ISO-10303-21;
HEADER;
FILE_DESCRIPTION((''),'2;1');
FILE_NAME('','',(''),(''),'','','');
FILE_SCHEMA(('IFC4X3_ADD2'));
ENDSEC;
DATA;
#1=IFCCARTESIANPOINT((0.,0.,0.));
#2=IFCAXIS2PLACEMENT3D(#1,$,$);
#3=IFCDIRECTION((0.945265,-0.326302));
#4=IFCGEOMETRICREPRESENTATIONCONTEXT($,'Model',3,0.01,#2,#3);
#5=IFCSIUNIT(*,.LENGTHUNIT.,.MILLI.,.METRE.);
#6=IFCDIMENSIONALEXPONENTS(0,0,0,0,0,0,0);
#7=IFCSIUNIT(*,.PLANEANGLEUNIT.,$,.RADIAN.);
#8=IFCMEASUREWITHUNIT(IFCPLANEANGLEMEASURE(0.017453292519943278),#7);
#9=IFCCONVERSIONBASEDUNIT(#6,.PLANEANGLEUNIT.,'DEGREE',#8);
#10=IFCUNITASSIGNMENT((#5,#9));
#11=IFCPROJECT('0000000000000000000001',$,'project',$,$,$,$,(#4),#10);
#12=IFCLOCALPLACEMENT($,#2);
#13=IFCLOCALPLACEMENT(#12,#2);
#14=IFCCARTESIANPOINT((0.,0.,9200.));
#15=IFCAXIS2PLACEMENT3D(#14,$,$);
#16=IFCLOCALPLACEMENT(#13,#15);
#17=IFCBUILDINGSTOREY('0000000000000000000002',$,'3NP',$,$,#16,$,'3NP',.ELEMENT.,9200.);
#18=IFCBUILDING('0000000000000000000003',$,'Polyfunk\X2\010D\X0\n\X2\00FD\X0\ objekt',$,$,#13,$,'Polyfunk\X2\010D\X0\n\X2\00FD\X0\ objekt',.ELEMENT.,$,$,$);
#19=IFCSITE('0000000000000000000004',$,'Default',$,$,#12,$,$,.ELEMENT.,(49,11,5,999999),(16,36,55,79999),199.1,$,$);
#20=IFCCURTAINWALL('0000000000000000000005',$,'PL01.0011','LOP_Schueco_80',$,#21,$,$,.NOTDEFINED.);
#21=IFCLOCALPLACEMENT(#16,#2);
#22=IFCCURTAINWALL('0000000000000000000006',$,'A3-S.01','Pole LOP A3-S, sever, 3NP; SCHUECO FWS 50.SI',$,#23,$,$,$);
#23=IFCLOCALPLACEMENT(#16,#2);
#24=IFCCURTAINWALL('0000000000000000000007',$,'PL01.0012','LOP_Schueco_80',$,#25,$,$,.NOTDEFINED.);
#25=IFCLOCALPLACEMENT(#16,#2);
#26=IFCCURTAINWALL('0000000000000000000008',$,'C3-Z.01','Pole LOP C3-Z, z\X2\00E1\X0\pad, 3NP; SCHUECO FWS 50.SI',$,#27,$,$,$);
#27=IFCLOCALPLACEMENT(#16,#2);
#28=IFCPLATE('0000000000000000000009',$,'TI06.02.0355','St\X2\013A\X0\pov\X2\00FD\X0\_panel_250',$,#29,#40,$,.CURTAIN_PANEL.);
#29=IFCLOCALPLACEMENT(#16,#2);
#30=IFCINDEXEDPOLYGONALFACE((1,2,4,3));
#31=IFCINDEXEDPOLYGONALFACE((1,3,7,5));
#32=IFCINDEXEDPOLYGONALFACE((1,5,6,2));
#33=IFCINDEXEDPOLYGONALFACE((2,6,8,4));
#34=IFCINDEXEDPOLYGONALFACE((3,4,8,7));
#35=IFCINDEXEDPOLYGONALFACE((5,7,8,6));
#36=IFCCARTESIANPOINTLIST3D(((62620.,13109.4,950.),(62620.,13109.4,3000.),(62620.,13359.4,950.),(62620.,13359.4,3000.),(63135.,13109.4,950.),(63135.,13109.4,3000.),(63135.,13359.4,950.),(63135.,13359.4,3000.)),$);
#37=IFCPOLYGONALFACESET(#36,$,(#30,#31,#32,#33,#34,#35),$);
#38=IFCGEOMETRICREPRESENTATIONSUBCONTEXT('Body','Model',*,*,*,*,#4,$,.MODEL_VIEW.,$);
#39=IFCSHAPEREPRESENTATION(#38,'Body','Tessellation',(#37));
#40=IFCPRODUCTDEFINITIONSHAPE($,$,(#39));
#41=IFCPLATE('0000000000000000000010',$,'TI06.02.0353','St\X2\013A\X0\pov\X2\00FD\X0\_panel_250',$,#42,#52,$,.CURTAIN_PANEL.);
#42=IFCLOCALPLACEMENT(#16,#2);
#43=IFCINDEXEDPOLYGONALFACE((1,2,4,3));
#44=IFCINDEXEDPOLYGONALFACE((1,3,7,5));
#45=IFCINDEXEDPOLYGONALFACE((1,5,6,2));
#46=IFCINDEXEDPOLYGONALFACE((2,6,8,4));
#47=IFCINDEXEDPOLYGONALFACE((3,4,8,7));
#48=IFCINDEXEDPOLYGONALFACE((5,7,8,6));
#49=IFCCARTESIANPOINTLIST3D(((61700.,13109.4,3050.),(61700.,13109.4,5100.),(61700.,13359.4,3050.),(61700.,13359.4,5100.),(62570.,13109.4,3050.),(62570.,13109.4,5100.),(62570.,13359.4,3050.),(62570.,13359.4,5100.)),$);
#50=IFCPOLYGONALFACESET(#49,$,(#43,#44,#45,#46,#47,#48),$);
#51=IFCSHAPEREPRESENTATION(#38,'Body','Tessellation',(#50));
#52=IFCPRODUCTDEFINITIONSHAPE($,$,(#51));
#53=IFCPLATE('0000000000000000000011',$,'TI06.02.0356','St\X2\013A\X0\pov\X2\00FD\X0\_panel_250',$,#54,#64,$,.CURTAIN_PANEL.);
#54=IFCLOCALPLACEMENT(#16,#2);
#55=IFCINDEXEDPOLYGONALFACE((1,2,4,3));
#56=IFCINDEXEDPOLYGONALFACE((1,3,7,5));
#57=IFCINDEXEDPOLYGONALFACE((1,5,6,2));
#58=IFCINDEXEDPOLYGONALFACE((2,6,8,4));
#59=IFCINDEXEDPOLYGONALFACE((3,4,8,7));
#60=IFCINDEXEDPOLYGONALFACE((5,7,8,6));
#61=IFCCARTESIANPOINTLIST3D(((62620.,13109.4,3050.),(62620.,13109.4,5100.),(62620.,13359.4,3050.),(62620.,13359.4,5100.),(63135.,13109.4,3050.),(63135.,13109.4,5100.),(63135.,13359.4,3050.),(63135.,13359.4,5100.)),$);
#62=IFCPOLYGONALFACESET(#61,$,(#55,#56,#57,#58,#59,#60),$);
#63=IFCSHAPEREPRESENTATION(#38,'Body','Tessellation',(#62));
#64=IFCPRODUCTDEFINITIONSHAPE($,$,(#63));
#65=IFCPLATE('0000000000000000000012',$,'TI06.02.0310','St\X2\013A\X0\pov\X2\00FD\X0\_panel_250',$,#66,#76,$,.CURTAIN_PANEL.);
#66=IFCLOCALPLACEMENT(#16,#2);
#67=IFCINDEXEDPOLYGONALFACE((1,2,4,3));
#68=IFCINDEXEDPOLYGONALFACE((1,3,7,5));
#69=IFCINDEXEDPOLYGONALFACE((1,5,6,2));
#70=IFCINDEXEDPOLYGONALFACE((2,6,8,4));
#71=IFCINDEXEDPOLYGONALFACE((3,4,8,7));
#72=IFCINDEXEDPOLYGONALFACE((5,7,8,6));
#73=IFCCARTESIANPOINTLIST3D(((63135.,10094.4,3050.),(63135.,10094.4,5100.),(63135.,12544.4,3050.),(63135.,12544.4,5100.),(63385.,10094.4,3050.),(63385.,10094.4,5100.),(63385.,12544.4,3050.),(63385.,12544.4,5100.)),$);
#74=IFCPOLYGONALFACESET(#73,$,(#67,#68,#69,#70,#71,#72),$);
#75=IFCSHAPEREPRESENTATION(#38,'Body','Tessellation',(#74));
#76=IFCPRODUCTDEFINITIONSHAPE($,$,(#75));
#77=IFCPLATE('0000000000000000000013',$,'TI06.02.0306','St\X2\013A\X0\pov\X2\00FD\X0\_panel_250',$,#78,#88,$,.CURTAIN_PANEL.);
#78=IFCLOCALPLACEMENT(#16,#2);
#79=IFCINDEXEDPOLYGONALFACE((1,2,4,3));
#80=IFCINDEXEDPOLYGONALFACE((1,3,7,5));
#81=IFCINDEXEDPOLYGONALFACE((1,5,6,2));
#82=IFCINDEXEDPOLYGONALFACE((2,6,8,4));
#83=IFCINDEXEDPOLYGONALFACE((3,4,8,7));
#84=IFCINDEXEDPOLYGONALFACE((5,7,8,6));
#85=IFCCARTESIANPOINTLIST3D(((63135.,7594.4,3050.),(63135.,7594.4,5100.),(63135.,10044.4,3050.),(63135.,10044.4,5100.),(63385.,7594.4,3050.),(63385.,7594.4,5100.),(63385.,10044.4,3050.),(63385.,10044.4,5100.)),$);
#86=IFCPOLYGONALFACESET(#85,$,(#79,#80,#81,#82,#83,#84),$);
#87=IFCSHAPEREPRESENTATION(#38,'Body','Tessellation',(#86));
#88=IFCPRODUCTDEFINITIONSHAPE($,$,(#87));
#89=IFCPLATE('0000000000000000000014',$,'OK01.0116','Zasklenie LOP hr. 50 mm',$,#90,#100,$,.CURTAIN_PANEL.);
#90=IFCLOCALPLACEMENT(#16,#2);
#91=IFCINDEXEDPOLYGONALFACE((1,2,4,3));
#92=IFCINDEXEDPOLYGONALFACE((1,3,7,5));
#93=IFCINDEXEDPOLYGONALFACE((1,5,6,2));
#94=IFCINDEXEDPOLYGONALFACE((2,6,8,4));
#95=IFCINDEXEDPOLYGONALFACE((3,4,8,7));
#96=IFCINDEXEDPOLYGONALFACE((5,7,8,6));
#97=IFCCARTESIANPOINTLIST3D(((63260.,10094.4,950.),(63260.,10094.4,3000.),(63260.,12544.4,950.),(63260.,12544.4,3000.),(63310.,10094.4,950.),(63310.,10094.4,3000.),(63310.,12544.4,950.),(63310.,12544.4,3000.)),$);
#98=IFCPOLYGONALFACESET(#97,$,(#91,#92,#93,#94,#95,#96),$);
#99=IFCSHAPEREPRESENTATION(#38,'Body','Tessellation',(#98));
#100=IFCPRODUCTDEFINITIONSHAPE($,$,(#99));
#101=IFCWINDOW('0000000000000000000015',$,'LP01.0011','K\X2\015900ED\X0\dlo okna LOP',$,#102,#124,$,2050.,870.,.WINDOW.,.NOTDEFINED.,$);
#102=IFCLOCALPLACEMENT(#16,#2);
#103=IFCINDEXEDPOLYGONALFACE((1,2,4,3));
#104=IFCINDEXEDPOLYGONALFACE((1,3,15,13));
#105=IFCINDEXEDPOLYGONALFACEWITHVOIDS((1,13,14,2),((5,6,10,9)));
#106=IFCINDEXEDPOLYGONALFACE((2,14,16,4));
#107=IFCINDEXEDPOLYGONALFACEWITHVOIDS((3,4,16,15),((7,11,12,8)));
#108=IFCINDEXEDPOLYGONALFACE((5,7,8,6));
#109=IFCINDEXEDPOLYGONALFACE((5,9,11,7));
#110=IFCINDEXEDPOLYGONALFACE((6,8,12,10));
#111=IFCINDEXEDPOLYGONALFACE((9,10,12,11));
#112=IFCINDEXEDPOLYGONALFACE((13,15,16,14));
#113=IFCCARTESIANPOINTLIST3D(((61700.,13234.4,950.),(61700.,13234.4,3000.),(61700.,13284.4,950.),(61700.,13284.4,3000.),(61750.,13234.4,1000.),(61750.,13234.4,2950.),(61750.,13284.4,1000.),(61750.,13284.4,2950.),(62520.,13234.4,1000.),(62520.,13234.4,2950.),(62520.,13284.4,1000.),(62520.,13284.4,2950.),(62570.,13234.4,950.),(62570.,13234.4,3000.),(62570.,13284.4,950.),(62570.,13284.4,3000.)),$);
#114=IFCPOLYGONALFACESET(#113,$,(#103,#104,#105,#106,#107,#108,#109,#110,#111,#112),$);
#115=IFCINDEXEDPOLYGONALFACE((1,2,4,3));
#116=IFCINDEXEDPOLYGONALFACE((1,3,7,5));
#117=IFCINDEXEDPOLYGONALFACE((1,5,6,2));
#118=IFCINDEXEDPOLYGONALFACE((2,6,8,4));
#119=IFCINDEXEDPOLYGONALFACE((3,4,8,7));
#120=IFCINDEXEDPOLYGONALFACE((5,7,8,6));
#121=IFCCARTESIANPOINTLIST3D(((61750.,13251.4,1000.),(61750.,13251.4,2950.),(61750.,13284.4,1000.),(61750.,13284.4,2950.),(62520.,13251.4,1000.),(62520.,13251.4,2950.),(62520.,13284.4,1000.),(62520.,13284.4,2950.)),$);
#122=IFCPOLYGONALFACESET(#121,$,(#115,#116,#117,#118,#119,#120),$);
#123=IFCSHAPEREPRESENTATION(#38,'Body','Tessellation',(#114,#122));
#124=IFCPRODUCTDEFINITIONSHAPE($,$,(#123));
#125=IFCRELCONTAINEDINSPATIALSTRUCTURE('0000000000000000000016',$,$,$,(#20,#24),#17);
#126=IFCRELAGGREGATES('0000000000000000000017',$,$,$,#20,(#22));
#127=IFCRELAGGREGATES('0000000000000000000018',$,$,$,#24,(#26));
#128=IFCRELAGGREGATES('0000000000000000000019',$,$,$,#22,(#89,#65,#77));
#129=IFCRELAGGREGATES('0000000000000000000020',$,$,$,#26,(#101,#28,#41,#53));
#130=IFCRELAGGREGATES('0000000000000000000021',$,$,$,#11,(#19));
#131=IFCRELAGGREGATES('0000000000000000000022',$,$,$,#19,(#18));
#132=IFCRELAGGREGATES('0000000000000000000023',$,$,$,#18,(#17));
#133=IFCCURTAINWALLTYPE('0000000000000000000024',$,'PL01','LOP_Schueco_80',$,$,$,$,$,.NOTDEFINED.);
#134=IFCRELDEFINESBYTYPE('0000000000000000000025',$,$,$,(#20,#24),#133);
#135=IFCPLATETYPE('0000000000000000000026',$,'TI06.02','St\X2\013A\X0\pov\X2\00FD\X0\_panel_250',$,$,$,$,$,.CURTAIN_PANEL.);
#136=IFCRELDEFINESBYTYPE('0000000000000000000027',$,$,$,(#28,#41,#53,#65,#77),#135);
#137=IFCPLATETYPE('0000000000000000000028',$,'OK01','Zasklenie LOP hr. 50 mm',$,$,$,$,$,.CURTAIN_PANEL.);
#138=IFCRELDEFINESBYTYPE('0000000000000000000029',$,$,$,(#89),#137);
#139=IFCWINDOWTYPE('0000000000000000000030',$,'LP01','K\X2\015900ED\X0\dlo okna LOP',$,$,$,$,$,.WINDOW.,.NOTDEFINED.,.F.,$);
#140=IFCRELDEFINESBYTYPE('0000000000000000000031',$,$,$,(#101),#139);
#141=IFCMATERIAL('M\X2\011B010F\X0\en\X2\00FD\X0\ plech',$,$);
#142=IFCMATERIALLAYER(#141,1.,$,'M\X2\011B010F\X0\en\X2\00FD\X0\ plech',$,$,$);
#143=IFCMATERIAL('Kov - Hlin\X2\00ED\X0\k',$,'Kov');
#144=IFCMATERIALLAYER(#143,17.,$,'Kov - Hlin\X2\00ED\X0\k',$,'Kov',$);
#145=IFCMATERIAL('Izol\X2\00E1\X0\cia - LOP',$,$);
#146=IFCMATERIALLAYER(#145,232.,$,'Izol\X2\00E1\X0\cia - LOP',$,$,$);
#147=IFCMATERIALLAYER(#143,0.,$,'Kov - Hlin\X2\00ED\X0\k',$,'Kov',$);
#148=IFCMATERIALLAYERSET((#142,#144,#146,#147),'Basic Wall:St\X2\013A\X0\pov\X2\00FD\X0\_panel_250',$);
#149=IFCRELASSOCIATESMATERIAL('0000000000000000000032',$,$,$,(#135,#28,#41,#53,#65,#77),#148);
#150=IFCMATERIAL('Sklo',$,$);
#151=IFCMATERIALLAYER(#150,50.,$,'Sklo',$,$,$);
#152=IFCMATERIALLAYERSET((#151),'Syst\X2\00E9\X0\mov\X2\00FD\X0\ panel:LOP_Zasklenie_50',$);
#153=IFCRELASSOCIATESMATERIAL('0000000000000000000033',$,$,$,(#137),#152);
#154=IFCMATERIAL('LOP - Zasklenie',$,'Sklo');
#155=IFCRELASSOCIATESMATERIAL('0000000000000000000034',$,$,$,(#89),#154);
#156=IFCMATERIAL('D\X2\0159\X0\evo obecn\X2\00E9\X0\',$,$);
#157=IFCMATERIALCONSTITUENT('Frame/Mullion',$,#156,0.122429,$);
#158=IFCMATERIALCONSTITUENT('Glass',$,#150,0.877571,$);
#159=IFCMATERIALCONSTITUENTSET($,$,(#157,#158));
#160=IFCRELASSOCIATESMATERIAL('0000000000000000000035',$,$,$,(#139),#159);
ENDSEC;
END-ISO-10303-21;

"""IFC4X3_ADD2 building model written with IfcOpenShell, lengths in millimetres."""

from ifc_helpers import new_model, entity, si_unit, converted_unit, direction, frame, frame_2d, origin, origin_2d_with_axis, place, context, subcontext, project, spatial, polyline, rectangle, outline, extrude, source, transform, mapped, material, layer, layer_set, layer_usage, constituent, constituent_set, type_object, type_shapes, element, aggregate, save


model = new_model("IFC4X3_ADD2")

# Units and contexts
model_context = context("Model", 3, precision=0.01, world=origin(), true_north=direction((0.945265, -0.326302)))
body_context = subcontext(model_context, "Body", "Model", "MODEL_VIEW")
ifc_project = project(units=[si_unit("LENGTHUNIT", "METRE", prefix="MILLI"), converted_unit("PLANEANGLEUNIT", "DEGREE", entity("IfcPlaneAngleMeasure", 0.017453292519943278), si_unit("PLANEANGLEUNIT", "RADIAN"), dimensions=[0, 0, 0, 0, 0, 0, 0])], contexts=[model_context])

# Site, building, storey
site_placement = place(None, origin())
site = spatial("IfcSite", under=ifc_project, at=site_placement, Name="Default", CompositionType="ELEMENT", RefLatitude=(49, 11, 5, 999999), RefLongitude=(16, 36, 55, 79999), RefElevation=199.1)
building_placement = place(site_placement, origin())
building = spatial("IfcBuilding", under=site, at=building_placement, Name="Polyfunkčný objekt", LongName="Polyfunkčný objekt", CompositionType="ELEMENT")
storey_placement = place(building_placement, frame((0.0, 0.0, 9200.0)))
storey = spatial("IfcBuildingStorey", under=building, at=storey_placement, Name="3NP", LongName="3NP", CompositionType="ELEMENT", Elevation=9200.0)

# Curtain walls
curtain_wall_type = type_object("IfcCurtainWallType", Name="PL01", Description="LOP_Schueco_80", PredefinedType="NOTDEFINED")
curtain_wall_1_placement = place(storey_placement, frame((0.0, 0.0, -9200.0)))
curtain_wall_1 = element("IfcCurtainWall", 1, at=curtain_wall_1_placement, inside=storey, type_object=curtain_wall_type, Name="PL01.0011", Description="LOP_Schueco_80", PredefinedType="NOTDEFINED")
curtain_wall_2 = element("IfcCurtainWall", 2, Name="A3-S.01", Description="Pole LOP A3-S, sever, 3NP; SCHUECO FWS 50.SI")
aggregate(curtain_wall_1, [curtain_wall_2])

# Curtain walls
curtain_wall_3_placement = place(storey_placement, frame((0.0, 0.0, -9200.0)))
curtain_wall_3 = element("IfcCurtainWall", 3, at=curtain_wall_3_placement, inside=storey, type_object=curtain_wall_type, Name="PL01.0012", Description="LOP_Schueco_80", PredefinedType="NOTDEFINED")
curtain_wall_4 = element("IfcCurtainWall", 4, Name="C3-Z.01", Description="Pole LOP C3-Z, západ, 3NP; SCHUECO FWS 50.SI")
aggregate(curtain_wall_3, [curtain_wall_4])

# Plates
ifc_material_1 = material(Name="Měďený plech")
ifc_layer_1 = layer(ifc_material_1, 1.0, Name="Měďený plech")
ifc_material_2 = material(Name="Kov - Hliník", Category="Kov")
ifc_layer_2 = layer(ifc_material_2, 17.0, Name="Kov - Hliník", Category="Kov")
ifc_material_3 = material(Name="Izolácia - LOP")
ifc_layer_3 = layer(ifc_material_3, 232.0, Name="Izolácia - LOP")
ifc_layer_4 = layer(ifc_material_2, 0.0, Name="Kov - Hliník", Category="Kov")
ifc_layer_set_1 = layer_set([ifc_layer_1, ifc_layer_2, ifc_layer_3, ifc_layer_4], Name="Basic Wall:Stĺpový_panel_250")
ifc_layer_usage_1 = layer_usage(ifc_layer_set_1, "AXIS2", "NEGATIVE", 125.0)
plate_type_1 = type_object("IfcPlateType", Name="TI06.02", Description="Stĺpový_panel_250", PredefinedType="CURTAIN_PANEL", material=ifc_layer_set_1)
plate_1_placement = place(storey_placement, frame((62620.0, 13234.4, 950.0)))
plate_1 = element("IfcPlate", 5, at=plate_1_placement, type_object=plate_type_1, material=ifc_layer_usage_1, Name="TI06.02.0355", Description="Stĺpový_panel_250", PredefinedType="CURTAIN_PANEL", context=body_context, shape_type="SweptSolid", body=[
    extrude(rectangle(XDim=250.0, YDim=515.0, at=frame_2d((0.0, 0.0), x_axis=(1.0, 0.0))), frame((257.5, 0.0, 0.0), z_axis=(0.0, 0.0, 1.0), x_axis=(0.0, 1.0, 0.0)), (0.0, 0.0, 1.0), 2050.0),
])
ifc_layer_usage_2 = layer_usage(ifc_layer_set_1, "AXIS2", "NEGATIVE", 125.0)
plate_2_placement = place(storey_placement, frame((61700.0, 13234.4, 3050.0)))
plate_2 = element("IfcPlate", 6, at=plate_2_placement, type_object=plate_type_1, material=ifc_layer_usage_2, Name="TI06.02.0353", Description="Stĺpový_panel_250", PredefinedType="CURTAIN_PANEL", context=body_context, shape_type="SweptSolid", body=[
    extrude(rectangle(XDim=250.0, YDim=870.0, at=frame_2d((0.0, 0.0), x_axis=(1.0, 0.0))), frame((435.0, 0.0, 0.0), z_axis=(0.0, 0.0, 1.0), x_axis=(0.0, 1.0, 0.0)), (0.0, 0.0, 1.0), 2050.0),
])
ifc_layer_usage_3 = layer_usage(ifc_layer_set_1, "AXIS2", "NEGATIVE", 125.0)
plate_3_placement = place(storey_placement, frame((62620.0, 13234.4, 3050.0)))
plate_3 = element("IfcPlate", 7, at=plate_3_placement, type_object=plate_type_1, material=ifc_layer_usage_3, Name="TI06.02.0356", Description="Stĺpový_panel_250", PredefinedType="CURTAIN_PANEL", context=body_context, shape_type="SweptSolid", body=[
    extrude(rectangle(XDim=250.0, YDim=515.0, at=frame_2d((0.0, 0.0), x_axis=(1.0, 0.0))), frame((257.5, 0.0, 0.0), z_axis=(0.0, 0.0, 1.0), x_axis=(0.0, 1.0, 0.0)), (0.0, 0.0, 1.0), 2050.0),
])
ifc_layer_usage_4 = layer_usage(ifc_layer_set_1, "AXIS2", "NEGATIVE", 125.0)
plate_4_placement = place(storey_placement, frame((63260.0, 12544.4, 3050.0), z_axis=(0.0, 0.0, 1.0), x_axis=(0.0, -1.0, 0.0)))
plate_4 = element("IfcPlate", 8, at=plate_4_placement, type_object=plate_type_1, material=ifc_layer_usage_4, Name="TI06.02.0310", Description="Stĺpový_panel_250", PredefinedType="CURTAIN_PANEL", context=body_context, shape_type="SweptSolid", body=[
    extrude(rectangle(XDim=250.0, YDim=2450.0, at=frame_2d((0.0, 0.0), x_axis=(1.0, 0.0))), frame((1225.0, 0.0, 0.0), z_axis=(0.0, 0.0, 1.0), x_axis=(0.0, 1.0, 0.0)), (0.0, 0.0, 1.0), 2050.0),
])
ifc_layer_usage_5 = layer_usage(ifc_layer_set_1, "AXIS2", "NEGATIVE", 125.0)
plate_5_placement = place(storey_placement, frame((63260.0, 10044.4, 3050.0), z_axis=(0.0, 0.0, 1.0), x_axis=(0.0, -1.0, 0.0)))
plate_5 = element("IfcPlate", 9, at=plate_5_placement, type_object=plate_type_1, material=ifc_layer_usage_5, Name="TI06.02.0306", Description="Stĺpový_panel_250", PredefinedType="CURTAIN_PANEL", context=body_context, shape_type="SweptSolid", body=[
    extrude(rectangle(XDim=250.0, YDim=2450.0, at=frame_2d((0.0, 0.0), x_axis=(1.0, 0.0))), frame((1225.0, 0.0, 0.0), z_axis=(0.0, 0.0, 1.0), x_axis=(0.0, 1.0, 0.0)), (0.0, 0.0, 1.0), 2050.0),
])
ifc_material_4 = material(Name="LOP - Zasklenie", Category="Sklo")
ifc_material_5 = material(Name="Sklo")
ifc_layer_5 = layer(ifc_material_5, 50.0, Name="Sklo")
ifc_layer_set_2 = layer_set([ifc_layer_5], Name="Systémový panel:LOP_Zasklenie_50")
plate_type_2 = type_object("IfcPlateType", Name="OK01", Description="Zasklenie LOP hr. 50 mm", PredefinedType="CURTAIN_PANEL", material=ifc_layer_set_2)
shared_shape_1 = source(origin(), body_context, "Body", "SweptSolid", [
    extrude(rectangle(XDim=50.0, YDim=2450.0, at=origin_2d_with_axis()), frame((0.0, 25.0, 0.0), z_axis=(0.0, 0.0, 1.0), x_axis=(0.0, 1.0, 0.0)), (0.0, 0.0, 1.0), 2050.0),
])
type_shapes(plate_type_2, [shared_shape_1])
plate_6_placement = place(curtain_wall_1_placement, frame((63260.0, 11319.4, 10150.0), z_axis=(0.0, 0.0, 1.0), x_axis=(0.0, -1.0, 0.0)))
plate_6 = element("IfcPlate", 10, at=plate_6_placement, type_object=plate_type_2, material=ifc_material_4, Name="OK01.0116", Description="Zasklenie LOP hr. 50 mm", PredefinedType="CURTAIN_PANEL", context=body_context, shape_type="MappedRepresentation", body=[
    mapped(shared_shape_1, transform((0.0, 0.0, 0.0), scale=1.0)),
])
aggregate(curtain_wall_2, [plate_6, plate_4, plate_5])

# Window
ifc_material_6 = material(Name="Dřevo obecné")
ifc_constituent_1 = constituent(ifc_material_6, Name="Frame/Mullion", fraction=0.122429)
ifc_constituent_2 = constituent(ifc_material_5, Name="Glass", fraction=0.877571)
ifc_constituent_set = constituent_set(constituents=[ifc_constituent_1, ifc_constituent_2])
window_type = type_object("IfcWindowType", Name="LP01", Description="Křídlo okna LOP", ParameterTakesPrecedence=False, PartitioningType="NOTDEFINED", PredefinedType="WINDOW", material=ifc_constituent_set)
shared_shape_2 = source(origin(), body_context, "Body", "SweptSolid", [
    extrude(outline(polyline([(-1025.0, -435.0), (1025.0, -435.0), (1025.0, 435.0), (-1025.0, 435.0), (-1025.0, -435.0)]), holes=[polyline([(-975.0, -385.0), (-975.0, 385.0), (975.0, 385.0), (975.0, -385.0), (-975.0, -385.0)])]), frame((0.0, 0.0, 1025.0), z_axis=(0.0, 1.0, 0.0), x_axis=(0.0, 0.0, -1.0)), (0.0, 0.0, 1.0), 50.0),
    extrude(rectangle(XDim=33.0, YDim=770.0, at=origin_2d_with_axis()), frame((0.0, 33.5, 50.0), z_axis=(0.0, 0.0, 1.0), x_axis=(0.0, -1.0, 0.0)), (0.0, 0.0, 1.0), 1950.0),
])
type_shapes(window_type, [shared_shape_2])
window_placement = place(curtain_wall_3_placement, frame((62135.0, 13234.4, 10150.0)))
window = element("IfcWindow", 11, at=window_placement, type_object=window_type, Name="LP01.0011", Description="Křídlo okna LOP", OverallHeight=2050.0, OverallWidth=870.0, PartitioningType="NOTDEFINED", PredefinedType="WINDOW", context=body_context, shape_type="MappedRepresentation", body=[
    mapped(shared_shape_2, transform((0.0, 0.0, 0.0), scale=1.0)),
])
aggregate(curtain_wall_4, [window, plate_1, plate_2, plate_3])

save(model, "model.ifc")
